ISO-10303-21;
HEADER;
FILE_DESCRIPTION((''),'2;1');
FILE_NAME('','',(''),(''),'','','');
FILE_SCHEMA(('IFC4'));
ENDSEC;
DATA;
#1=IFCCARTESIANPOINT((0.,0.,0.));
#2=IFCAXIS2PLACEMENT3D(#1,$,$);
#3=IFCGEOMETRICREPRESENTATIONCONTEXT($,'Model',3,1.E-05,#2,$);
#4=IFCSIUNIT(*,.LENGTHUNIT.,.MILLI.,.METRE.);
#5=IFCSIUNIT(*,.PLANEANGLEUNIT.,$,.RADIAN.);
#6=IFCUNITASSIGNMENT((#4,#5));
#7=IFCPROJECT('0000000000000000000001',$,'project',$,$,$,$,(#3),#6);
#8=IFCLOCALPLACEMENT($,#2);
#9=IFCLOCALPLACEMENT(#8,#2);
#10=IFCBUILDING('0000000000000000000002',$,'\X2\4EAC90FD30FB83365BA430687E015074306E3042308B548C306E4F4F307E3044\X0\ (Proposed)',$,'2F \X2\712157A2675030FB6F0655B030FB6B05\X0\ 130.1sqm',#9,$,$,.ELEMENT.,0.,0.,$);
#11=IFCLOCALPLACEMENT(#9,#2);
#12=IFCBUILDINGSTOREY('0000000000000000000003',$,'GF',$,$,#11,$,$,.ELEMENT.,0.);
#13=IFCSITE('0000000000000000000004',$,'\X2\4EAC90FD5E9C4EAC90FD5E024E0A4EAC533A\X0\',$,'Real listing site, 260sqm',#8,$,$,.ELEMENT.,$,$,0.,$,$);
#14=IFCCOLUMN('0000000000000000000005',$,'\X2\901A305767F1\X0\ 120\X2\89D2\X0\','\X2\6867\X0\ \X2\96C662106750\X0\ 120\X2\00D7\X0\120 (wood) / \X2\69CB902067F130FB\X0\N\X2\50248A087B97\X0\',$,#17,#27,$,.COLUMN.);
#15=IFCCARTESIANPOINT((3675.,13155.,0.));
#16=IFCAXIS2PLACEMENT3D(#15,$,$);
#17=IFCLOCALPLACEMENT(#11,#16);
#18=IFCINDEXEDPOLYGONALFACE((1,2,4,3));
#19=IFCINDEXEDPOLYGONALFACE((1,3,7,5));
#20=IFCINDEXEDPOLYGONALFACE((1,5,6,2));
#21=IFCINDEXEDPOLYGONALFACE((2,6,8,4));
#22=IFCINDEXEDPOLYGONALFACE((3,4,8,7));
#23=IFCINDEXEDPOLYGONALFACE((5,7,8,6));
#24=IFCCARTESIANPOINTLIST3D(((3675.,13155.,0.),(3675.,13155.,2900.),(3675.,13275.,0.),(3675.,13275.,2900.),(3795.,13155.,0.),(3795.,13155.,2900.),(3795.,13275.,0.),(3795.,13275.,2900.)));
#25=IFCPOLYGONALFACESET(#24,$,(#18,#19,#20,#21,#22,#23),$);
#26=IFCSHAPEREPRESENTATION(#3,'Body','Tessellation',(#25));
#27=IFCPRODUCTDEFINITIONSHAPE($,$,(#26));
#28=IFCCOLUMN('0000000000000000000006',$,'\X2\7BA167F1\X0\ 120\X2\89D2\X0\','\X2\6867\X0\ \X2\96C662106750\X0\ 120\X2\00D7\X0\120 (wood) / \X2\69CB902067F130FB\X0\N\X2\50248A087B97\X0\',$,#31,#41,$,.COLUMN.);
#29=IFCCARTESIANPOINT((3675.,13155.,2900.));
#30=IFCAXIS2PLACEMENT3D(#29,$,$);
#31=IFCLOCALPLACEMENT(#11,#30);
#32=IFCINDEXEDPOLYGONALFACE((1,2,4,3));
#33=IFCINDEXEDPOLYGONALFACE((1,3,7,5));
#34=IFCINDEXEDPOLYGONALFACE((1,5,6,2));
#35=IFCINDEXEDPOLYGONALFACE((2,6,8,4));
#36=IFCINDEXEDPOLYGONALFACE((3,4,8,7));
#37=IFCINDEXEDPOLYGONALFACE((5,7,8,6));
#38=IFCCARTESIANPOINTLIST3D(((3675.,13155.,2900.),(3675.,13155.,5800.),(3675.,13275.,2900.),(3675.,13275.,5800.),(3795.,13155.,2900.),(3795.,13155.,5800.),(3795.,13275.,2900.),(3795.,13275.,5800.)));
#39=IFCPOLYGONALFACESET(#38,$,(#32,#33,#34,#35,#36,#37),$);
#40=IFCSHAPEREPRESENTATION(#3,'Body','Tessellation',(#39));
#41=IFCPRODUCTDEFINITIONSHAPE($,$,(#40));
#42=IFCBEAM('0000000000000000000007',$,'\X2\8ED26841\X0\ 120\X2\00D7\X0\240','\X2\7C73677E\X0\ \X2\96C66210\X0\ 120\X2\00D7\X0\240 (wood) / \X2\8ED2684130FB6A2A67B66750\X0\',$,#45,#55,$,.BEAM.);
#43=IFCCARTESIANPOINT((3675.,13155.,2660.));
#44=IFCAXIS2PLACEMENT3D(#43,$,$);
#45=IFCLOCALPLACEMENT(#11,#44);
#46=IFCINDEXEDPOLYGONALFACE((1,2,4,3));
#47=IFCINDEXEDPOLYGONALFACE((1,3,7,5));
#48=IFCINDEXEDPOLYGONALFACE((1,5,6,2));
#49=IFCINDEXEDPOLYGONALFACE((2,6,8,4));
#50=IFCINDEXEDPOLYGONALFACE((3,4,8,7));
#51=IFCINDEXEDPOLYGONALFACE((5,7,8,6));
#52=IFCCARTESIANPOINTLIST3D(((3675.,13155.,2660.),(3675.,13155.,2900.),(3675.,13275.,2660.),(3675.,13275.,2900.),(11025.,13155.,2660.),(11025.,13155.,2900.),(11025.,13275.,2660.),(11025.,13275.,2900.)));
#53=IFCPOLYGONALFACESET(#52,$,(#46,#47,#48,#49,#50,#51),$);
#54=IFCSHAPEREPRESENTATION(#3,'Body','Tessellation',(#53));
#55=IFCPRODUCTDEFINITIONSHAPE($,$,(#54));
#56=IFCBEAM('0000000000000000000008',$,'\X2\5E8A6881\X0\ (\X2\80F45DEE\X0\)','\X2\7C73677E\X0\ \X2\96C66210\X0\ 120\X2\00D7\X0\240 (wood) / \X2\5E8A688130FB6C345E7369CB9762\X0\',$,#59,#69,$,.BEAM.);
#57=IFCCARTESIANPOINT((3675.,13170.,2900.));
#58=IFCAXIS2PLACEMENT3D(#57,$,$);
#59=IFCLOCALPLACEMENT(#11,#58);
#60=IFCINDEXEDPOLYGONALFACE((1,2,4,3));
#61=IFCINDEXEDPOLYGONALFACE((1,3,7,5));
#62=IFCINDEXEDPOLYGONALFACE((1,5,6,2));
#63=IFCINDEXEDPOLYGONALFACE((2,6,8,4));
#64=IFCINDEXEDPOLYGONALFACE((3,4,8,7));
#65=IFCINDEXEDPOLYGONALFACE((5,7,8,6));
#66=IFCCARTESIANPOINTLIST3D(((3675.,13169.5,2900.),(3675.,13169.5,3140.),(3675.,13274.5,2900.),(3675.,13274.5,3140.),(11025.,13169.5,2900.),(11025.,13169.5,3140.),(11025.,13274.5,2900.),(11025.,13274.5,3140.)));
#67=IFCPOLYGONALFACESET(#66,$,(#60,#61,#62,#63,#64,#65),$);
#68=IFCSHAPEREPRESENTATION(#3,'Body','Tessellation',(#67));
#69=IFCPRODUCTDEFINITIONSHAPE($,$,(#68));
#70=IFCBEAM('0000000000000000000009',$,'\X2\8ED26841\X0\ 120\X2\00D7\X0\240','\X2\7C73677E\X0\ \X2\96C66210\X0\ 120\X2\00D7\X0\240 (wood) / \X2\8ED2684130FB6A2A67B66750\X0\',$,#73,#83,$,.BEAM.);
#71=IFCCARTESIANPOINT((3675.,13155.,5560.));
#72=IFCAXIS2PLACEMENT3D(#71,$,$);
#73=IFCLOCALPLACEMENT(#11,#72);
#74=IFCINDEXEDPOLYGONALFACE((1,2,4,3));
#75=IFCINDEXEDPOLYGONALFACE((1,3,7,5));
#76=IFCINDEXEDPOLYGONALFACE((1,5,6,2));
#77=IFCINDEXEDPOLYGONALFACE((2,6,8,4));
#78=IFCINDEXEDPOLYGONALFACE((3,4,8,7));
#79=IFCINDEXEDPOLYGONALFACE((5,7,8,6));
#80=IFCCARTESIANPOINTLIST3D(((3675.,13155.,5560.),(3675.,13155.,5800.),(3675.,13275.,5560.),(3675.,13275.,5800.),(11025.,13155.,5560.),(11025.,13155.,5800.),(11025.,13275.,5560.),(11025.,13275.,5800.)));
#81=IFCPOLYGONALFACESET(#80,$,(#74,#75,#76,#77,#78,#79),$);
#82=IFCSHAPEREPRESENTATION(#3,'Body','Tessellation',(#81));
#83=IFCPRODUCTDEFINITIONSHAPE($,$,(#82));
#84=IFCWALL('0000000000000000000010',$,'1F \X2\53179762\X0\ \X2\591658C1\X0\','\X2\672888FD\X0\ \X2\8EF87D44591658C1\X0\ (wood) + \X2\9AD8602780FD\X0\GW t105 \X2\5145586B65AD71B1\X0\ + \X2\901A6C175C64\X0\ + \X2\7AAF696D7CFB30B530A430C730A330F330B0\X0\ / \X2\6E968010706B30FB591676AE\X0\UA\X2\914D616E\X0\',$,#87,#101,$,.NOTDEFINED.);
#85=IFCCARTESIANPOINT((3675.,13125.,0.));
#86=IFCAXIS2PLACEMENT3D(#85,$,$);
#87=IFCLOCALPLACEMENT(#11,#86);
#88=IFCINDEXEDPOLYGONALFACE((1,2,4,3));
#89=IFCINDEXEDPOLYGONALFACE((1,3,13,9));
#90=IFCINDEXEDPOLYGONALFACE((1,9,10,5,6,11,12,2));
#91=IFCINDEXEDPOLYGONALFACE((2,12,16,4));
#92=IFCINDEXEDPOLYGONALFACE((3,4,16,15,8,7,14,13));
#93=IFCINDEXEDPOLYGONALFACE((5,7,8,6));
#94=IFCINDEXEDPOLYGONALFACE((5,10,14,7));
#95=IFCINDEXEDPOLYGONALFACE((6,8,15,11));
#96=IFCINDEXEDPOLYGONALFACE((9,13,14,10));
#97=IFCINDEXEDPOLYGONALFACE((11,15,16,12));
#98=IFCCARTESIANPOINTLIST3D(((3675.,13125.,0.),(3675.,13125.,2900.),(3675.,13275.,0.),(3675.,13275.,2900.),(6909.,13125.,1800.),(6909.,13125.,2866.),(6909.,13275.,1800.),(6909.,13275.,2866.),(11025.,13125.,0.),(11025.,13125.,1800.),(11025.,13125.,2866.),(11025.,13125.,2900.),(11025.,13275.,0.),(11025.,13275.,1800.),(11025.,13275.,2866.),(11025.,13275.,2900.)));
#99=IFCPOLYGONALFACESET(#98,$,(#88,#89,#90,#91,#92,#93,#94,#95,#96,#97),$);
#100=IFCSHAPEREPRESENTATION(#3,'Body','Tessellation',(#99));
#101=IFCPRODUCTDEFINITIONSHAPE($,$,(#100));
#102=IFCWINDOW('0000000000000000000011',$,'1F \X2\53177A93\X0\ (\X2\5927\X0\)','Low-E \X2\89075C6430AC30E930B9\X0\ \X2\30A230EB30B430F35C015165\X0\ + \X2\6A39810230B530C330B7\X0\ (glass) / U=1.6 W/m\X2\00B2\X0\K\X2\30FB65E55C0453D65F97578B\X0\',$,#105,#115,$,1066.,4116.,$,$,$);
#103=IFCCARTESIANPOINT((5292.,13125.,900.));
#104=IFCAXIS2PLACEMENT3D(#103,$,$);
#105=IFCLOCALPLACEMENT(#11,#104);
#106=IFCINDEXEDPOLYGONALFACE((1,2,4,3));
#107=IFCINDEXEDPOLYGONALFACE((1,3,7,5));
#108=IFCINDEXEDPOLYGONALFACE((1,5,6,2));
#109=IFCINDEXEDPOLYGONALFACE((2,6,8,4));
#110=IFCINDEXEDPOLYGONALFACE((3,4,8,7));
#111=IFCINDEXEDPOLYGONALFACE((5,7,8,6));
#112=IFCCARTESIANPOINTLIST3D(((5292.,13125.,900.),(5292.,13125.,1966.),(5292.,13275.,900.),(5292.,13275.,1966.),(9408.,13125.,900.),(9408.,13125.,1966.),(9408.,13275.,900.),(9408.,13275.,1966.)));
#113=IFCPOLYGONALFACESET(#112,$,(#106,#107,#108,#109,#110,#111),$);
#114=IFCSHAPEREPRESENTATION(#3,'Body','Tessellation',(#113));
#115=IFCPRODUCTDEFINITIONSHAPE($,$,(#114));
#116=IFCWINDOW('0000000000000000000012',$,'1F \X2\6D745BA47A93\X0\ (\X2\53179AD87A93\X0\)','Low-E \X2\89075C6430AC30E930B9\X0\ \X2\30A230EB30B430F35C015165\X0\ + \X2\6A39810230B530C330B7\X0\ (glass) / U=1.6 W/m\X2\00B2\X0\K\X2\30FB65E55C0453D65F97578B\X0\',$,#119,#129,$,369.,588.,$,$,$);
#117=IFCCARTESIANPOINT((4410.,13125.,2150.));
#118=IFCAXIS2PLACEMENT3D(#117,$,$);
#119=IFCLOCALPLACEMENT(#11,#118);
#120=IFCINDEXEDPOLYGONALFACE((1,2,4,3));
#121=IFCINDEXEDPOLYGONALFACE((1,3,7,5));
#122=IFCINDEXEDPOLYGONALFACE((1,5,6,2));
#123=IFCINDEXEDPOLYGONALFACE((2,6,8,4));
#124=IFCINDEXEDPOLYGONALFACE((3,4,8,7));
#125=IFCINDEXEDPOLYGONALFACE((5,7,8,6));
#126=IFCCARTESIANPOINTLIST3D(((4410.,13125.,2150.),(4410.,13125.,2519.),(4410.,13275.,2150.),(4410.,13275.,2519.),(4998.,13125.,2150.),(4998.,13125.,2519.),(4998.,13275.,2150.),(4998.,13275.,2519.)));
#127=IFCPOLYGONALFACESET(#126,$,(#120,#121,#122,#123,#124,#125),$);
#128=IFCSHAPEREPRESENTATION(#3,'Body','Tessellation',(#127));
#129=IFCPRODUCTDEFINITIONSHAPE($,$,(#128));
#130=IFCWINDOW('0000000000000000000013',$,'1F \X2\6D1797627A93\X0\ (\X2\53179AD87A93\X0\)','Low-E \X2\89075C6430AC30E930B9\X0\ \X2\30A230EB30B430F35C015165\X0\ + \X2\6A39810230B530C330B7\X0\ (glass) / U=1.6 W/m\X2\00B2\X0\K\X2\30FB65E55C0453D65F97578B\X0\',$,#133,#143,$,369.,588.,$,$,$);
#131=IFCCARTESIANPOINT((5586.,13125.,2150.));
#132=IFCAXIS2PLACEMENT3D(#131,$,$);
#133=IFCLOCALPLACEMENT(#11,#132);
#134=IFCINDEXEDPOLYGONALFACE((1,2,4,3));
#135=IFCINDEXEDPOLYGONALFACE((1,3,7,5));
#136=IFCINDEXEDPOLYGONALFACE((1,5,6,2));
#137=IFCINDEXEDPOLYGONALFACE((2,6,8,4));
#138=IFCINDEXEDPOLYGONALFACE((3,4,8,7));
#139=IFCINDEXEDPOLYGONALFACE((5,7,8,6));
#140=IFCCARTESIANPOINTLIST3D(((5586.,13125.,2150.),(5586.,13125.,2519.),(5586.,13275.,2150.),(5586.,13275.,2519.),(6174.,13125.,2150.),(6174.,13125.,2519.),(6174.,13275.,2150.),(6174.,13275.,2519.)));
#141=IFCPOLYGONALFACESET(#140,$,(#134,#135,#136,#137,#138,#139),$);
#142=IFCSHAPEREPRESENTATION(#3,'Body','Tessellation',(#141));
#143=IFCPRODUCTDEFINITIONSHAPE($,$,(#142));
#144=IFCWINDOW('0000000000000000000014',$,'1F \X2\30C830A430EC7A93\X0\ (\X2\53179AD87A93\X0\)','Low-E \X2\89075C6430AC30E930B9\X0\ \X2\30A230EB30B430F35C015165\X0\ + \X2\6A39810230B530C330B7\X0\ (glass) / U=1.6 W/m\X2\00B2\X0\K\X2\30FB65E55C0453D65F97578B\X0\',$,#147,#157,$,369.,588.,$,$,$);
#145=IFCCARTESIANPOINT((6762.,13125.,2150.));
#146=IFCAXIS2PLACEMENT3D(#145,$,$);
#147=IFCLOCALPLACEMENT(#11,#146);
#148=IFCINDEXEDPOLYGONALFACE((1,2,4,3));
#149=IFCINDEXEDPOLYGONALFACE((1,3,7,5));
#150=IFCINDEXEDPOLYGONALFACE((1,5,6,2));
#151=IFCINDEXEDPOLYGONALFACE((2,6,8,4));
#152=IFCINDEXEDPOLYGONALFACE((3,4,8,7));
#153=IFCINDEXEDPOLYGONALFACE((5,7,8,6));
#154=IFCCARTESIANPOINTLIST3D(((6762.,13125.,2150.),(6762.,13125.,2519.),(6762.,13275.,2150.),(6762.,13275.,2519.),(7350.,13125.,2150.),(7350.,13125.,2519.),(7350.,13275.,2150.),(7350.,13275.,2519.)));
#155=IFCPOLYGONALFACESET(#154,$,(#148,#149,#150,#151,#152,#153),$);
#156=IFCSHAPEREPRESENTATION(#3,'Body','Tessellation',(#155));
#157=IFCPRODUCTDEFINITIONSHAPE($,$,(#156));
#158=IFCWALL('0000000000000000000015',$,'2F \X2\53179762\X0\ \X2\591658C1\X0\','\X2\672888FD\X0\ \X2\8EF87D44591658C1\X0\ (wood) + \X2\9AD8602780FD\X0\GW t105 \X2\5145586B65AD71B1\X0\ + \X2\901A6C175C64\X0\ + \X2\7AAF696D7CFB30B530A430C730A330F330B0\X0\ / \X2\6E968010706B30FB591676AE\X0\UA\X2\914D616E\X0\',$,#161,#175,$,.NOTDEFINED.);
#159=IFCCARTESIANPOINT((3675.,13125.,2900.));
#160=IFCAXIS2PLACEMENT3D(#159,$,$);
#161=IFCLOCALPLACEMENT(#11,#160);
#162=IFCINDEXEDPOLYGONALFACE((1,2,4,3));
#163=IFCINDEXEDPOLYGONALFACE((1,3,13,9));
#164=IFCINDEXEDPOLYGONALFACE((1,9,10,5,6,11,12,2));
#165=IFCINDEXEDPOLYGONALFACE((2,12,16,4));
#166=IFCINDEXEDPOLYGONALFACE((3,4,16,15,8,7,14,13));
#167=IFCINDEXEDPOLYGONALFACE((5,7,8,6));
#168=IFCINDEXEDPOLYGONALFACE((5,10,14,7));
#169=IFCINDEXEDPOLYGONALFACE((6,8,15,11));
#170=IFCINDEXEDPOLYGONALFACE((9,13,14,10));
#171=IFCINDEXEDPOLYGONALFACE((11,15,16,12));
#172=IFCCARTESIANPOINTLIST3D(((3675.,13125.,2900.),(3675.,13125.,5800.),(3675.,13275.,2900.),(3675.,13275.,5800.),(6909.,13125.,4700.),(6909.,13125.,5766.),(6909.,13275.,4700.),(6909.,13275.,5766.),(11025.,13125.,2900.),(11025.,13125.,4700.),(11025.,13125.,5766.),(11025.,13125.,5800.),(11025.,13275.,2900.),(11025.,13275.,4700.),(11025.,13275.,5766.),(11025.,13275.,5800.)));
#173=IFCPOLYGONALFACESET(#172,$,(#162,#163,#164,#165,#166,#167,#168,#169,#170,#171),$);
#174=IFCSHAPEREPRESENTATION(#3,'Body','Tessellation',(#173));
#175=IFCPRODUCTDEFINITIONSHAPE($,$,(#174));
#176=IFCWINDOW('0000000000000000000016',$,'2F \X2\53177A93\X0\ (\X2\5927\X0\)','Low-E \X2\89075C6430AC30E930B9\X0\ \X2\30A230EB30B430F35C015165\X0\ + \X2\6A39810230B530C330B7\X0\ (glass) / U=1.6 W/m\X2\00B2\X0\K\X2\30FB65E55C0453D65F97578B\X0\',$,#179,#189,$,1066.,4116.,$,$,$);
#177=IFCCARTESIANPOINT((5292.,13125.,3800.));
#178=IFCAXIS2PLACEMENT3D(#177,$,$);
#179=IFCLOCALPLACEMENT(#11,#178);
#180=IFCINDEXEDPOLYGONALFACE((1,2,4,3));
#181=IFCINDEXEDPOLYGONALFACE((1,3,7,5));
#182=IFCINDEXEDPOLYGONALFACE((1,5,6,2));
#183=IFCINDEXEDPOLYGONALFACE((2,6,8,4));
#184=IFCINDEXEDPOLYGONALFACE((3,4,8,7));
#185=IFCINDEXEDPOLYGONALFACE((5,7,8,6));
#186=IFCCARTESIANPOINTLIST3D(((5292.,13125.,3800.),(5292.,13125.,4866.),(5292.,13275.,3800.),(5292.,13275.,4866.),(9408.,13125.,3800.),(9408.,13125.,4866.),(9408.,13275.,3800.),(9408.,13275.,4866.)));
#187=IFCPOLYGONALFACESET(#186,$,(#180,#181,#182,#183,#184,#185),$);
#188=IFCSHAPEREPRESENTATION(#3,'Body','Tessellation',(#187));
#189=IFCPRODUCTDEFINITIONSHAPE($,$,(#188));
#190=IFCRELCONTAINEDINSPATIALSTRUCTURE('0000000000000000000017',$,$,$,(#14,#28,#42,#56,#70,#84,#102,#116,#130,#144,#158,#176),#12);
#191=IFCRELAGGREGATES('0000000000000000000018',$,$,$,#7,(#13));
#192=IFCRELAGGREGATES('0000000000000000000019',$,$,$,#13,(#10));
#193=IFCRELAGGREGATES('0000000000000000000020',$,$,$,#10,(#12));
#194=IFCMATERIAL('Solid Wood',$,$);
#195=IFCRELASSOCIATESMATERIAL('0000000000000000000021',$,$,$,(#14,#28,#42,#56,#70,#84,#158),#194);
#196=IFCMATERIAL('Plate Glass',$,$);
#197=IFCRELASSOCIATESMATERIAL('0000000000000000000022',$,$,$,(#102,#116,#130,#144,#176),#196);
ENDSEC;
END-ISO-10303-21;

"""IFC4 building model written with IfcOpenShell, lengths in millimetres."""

from ifc_helpers import new_model, si_unit, frame, frame_2d, origin, place, context, project, spatial, rectangle, extrude, material, element, fill, save


model = new_model("IFC4")

# Units and contexts
model_context = context("Model", 3, precision=1e-05, world=origin())
ifc_project = project(units=[si_unit("LENGTHUNIT", "METRE", prefix="MILLI"), si_unit("PLANEANGLEUNIT", "RADIAN")], contexts=[model_context])

# Site, building, storey
site_placement = place(None, origin())
site = spatial("IfcSite", under=ifc_project, at=site_placement, Name="京都府京都市上京区", ObjectType="Real listing site, 260sqm", CompositionType="ELEMENT", RefElevation=0.0)
building_placement = place(site_placement, origin())
building = spatial("IfcBuilding", under=site, at=building_placement, Name="京都・茶室と縁側のある和の住まい (Proposed)", ObjectType="2F 無垢材・漆喰・欅 130.1sqm", CompositionType="ELEMENT", ElevationOfRefHeight=0.0, ElevationOfTerrain=0.0)
storey_placement = place(building_placement, origin())
storey = spatial("IfcBuildingStorey", under=building, at=storey_placement, Name="GF", CompositionType="ELEMENT", Elevation=0.0)

# Columns
ifc_material_1 = material(Name="Solid Wood")
column_1_placement = place(storey_placement, frame((3675.0, 13155.0, 0.0)))
element("IfcColumn", 1, at=column_1_placement, inside=storey, material=ifc_material_1, Name="通し柱 120角", Description="桧 集成材 120×120 (wood) / 構造柱・N値計算", PredefinedType="COLUMN", context=model_context, shape_type="SweptSolid", body=[
    extrude(rectangle(XDim=120.0, YDim=120.0, at=frame_2d((60.0, 60.0))), frame((3675.0, 13155.0, 0.0)), (0.0, 0.0, 1.0), 2900.0),
])
column_2_placement = place(storey_placement, frame((3675.0, 13155.0, 2900.0)))
element("IfcColumn", 2, at=column_2_placement, inside=storey, material=ifc_material_1, Name="管柱 120角", Description="桧 集成材 120×120 (wood) / 構造柱・N値計算", PredefinedType="COLUMN", context=model_context, shape_type="SweptSolid", body=[
    extrude(rectangle(XDim=120.0, YDim=120.0, at=frame_2d((60.0, 60.0))), frame((3675.0, 13155.0, 2900.0)), (0.0, 0.0, 1.0), 2900.0),
])

# Beams
beam_1_placement = place(storey_placement, frame((3675.0, 13155.0, 2660.0)))
element("IfcBeam", 3, at=beam_1_placement, inside=storey, material=ifc_material_1, Name="軒桁 120×240", Description="米松 集成 120×240 (wood) / 軒桁・横架材", PredefinedType="BEAM", context=model_context, shape_type="SweptSolid", body=[
    extrude(rectangle(XDim=7350.0, YDim=120.0, at=frame_2d((3675.0, 60.0))), frame((3675.0, 13155.0, 2660.0)), (0.0, 0.0, 1.0), 240.0),
])
beam_2_placement = place(storey_placement, frame((3675.0, 13170.0, 2900.0)))
element("IfcBeam", 4, at=beam_2_placement, inside=storey, material=ifc_material_1, Name="床梁 (胴差)", Description="米松 集成 120×240 (wood) / 床梁・水平構面", PredefinedType="BEAM", context=model_context, shape_type="SweptSolid", body=[
    extrude(rectangle(XDim=7350.0, YDim=105.0, at=frame_2d((3675.0, 52.0))), frame((3675.0, 13170.0, 2900.0)), (0.0, 0.0, 1.0), 240.0),
])
beam_3_placement = place(storey_placement, frame((3675.0, 13155.0, 5560.0)))
element("IfcBeam", 5, at=beam_3_placement, inside=storey, material=ifc_material_1, Name="軒桁 120×240", Description="米松 集成 120×240 (wood) / 軒桁・横架材", PredefinedType="BEAM", context=model_context, shape_type="SweptSolid", body=[
    extrude(rectangle(XDim=7350.0, YDim=120.0, at=frame_2d((3675.0, 60.0))), frame((3675.0, 13155.0, 5560.0)), (0.0, 0.0, 1.0), 240.0),
])

# Wall, openings, windows
wall_1_placement = place(storey_placement, frame((3675.0, 13125.0, 0.0)))
wall_1 = element("IfcWall", 6, at=wall_1_placement, inside=storey, material=ifc_material_1, Name="1F 北面 外壁", Description="木製 軸組外壁 (wood) + 高性能GW t105 充填断熱 + 通気層 + 窯業系サイディング / 準耐火・外皮UA配慮", PredefinedType="NOTDEFINED", context=model_context, shape_type="SweptSolid", body=[
    extrude(rectangle(XDim=7350.0, YDim=150.0, at=frame_2d((3675.0, 75.0))), frame((3675.0, 13125.0, 0.0)), (0.0, 0.0, 1.0), 2900.0),
])
opening_1_placement = place(storey_placement, frame((5292.0, 13125.0, 900.0)))
opening_1 = element("IfcOpeningElement", 7, at=opening_1_placement, cuts=wall_1, PredefinedType="NOTDEFINED", context=model_context, shape_type="SweptSolid", body=[
    extrude(rectangle(XDim=4116.0, YDim=150.0, at=frame_2d((2058.0, 75.0))), frame((5292.0, 13125.0, 900.0)), (0.0, 0.0, 1.0), 1066.0),
])
opening_2_placement = place(storey_placement, frame((4410.0, 13125.0, 2150.0)))
opening_2 = element("IfcOpeningElement", 8, at=opening_2_placement, cuts=wall_1, PredefinedType="NOTDEFINED", context=model_context, shape_type="SweptSolid", body=[
    extrude(rectangle(XDim=588.0, YDim=150.0, at=frame_2d((294.0, 75.0))), frame((4410.0, 13125.0, 2150.0)), (0.0, 0.0, 1.0), 369.0),
])
opening_3_placement = place(storey_placement, frame((5586.0, 13125.0, 2150.0)))
opening_3 = element("IfcOpeningElement", 9, at=opening_3_placement, cuts=wall_1, PredefinedType="NOTDEFINED", context=model_context, shape_type="SweptSolid", body=[
    extrude(rectangle(XDim=588.0, YDim=150.0, at=frame_2d((294.0, 75.0))), frame((5586.0, 13125.0, 2150.0)), (0.0, 0.0, 1.0), 369.0),
])
opening_4_placement = place(storey_placement, frame((6762.0, 13125.0, 2150.0)))
opening_4 = element("IfcOpeningElement", 10, at=opening_4_placement, cuts=wall_1, PredefinedType="NOTDEFINED", context=model_context, shape_type="SweptSolid", body=[
    extrude(rectangle(XDim=588.0, YDim=150.0, at=frame_2d((294.0, 75.0))), frame((6762.0, 13125.0, 2150.0)), (0.0, 0.0, 1.0), 369.0),
])
ifc_material_2 = material(Name="Plate Glass")
window_1_placement = place(storey_placement, frame((5292.0, 13125.0, 900.0)))
window_1 = element("IfcWindow", 11, at=window_1_placement, inside=storey, material=ifc_material_2, Name="1F 北窓 (大)", Description="Low-E 複層ガラス アルゴン封入 + 樹脂サッシ (glass) / U=1.6 W/m²K・日射取得型", OverallHeight=1066.0, OverallWidth=4116.0, context=model_context, shape_type="SweptSolid", body=[
    extrude(rectangle(XDim=4116.0, YDim=150.0, at=frame_2d((2058.0, 75.0))), frame((5292.0, 13125.0, 900.0)), (0.0, 0.0, 1.0), 1066.0),
])
fill(opening_1, window_1)
window_2_placement = place(storey_placement, frame((4410.0, 13125.0, 2150.0)))
window_2 = element("IfcWindow", 12, at=window_2_placement, inside=storey, material=ifc_material_2, Name="1F 浴室窓 (北高窓)", Description="Low-E 複層ガラス アルゴン封入 + 樹脂サッシ (glass) / U=1.6 W/m²K・日射取得型", OverallHeight=369.0, OverallWidth=588.0, context=model_context, shape_type="SweptSolid", body=[
    extrude(rectangle(XDim=588.0, YDim=150.0, at=frame_2d((294.0, 75.0))), frame((4410.0, 13125.0, 2150.0)), (0.0, 0.0, 1.0), 369.0),
])
fill(opening_2, window_2)
window_3_placement = place(storey_placement, frame((5586.0, 13125.0, 2150.0)))
window_3 = element("IfcWindow", 13, at=window_3_placement, inside=storey, material=ifc_material_2, Name="1F 洗面窓 (北高窓)", Description="Low-E 複層ガラス アルゴン封入 + 樹脂サッシ (glass) / U=1.6 W/m²K・日射取得型", OverallHeight=369.0, OverallWidth=588.0, context=model_context, shape_type="SweptSolid", body=[
    extrude(rectangle(XDim=588.0, YDim=150.0, at=frame_2d((294.0, 75.0))), frame((5586.0, 13125.0, 2150.0)), (0.0, 0.0, 1.0), 369.0),
])
fill(opening_3, window_3)
window_4_placement = place(storey_placement, frame((6762.0, 13125.0, 2150.0)))
window_4 = element("IfcWindow", 14, at=window_4_placement, inside=storey, material=ifc_material_2, Name="1F トイレ窓 (北高窓)", Description="Low-E 複層ガラス アルゴン封入 + 樹脂サッシ (glass) / U=1.6 W/m²K・日射取得型", OverallHeight=369.0, OverallWidth=588.0, context=model_context, shape_type="SweptSolid", body=[
    extrude(rectangle(XDim=588.0, YDim=150.0, at=frame_2d((294.0, 75.0))), frame((6762.0, 13125.0, 2150.0)), (0.0, 0.0, 1.0), 369.0),
])
fill(opening_4, window_4)

# Wall, opening, window
wall_2_placement = place(storey_placement, frame((3675.0, 13125.0, 2900.0)))
wall_2 = element("IfcWall", 15, at=wall_2_placement, inside=storey, material=ifc_material_1, Name="2F 北面 外壁", Description="木製 軸組外壁 (wood) + 高性能GW t105 充填断熱 + 通気層 + 窯業系サイディング / 準耐火・外皮UA配慮", PredefinedType="NOTDEFINED", context=model_context, shape_type="SweptSolid", body=[
    extrude(rectangle(XDim=7350.0, YDim=150.0, at=frame_2d((3675.0, 75.0))), frame((3675.0, 13125.0, 2900.0)), (0.0, 0.0, 1.0), 2900.0),
])
opening_5_placement = place(storey_placement, frame((5292.0, 13125.0, 3800.0)))
opening_5 = element("IfcOpeningElement", 16, at=opening_5_placement, cuts=wall_2, PredefinedType="NOTDEFINED", context=model_context, shape_type="SweptSolid", body=[
    extrude(rectangle(XDim=4116.0, YDim=150.0, at=frame_2d((2058.0, 75.0))), frame((5292.0, 13125.0, 3800.0)), (0.0, 0.0, 1.0), 1066.0),
])
window_5_placement = place(storey_placement, frame((5292.0, 13125.0, 3800.0)))
window_5 = element("IfcWindow", 17, at=window_5_placement, inside=storey, material=ifc_material_2, Name="2F 北窓 (大)", Description="Low-E 複層ガラス アルゴン封入 + 樹脂サッシ (glass) / U=1.6 W/m²K・日射取得型", OverallHeight=1066.0, OverallWidth=4116.0, context=model_context, shape_type="SweptSolid", body=[
    extrude(rectangle(XDim=4116.0, YDim=150.0, at=frame_2d((2058.0, 75.0))), frame((5292.0, 13125.0, 3800.0)), (0.0, 0.0, 1.0), 1066.0),
])
fill(opening_5, window_5)

save(model, "model.ifc")
